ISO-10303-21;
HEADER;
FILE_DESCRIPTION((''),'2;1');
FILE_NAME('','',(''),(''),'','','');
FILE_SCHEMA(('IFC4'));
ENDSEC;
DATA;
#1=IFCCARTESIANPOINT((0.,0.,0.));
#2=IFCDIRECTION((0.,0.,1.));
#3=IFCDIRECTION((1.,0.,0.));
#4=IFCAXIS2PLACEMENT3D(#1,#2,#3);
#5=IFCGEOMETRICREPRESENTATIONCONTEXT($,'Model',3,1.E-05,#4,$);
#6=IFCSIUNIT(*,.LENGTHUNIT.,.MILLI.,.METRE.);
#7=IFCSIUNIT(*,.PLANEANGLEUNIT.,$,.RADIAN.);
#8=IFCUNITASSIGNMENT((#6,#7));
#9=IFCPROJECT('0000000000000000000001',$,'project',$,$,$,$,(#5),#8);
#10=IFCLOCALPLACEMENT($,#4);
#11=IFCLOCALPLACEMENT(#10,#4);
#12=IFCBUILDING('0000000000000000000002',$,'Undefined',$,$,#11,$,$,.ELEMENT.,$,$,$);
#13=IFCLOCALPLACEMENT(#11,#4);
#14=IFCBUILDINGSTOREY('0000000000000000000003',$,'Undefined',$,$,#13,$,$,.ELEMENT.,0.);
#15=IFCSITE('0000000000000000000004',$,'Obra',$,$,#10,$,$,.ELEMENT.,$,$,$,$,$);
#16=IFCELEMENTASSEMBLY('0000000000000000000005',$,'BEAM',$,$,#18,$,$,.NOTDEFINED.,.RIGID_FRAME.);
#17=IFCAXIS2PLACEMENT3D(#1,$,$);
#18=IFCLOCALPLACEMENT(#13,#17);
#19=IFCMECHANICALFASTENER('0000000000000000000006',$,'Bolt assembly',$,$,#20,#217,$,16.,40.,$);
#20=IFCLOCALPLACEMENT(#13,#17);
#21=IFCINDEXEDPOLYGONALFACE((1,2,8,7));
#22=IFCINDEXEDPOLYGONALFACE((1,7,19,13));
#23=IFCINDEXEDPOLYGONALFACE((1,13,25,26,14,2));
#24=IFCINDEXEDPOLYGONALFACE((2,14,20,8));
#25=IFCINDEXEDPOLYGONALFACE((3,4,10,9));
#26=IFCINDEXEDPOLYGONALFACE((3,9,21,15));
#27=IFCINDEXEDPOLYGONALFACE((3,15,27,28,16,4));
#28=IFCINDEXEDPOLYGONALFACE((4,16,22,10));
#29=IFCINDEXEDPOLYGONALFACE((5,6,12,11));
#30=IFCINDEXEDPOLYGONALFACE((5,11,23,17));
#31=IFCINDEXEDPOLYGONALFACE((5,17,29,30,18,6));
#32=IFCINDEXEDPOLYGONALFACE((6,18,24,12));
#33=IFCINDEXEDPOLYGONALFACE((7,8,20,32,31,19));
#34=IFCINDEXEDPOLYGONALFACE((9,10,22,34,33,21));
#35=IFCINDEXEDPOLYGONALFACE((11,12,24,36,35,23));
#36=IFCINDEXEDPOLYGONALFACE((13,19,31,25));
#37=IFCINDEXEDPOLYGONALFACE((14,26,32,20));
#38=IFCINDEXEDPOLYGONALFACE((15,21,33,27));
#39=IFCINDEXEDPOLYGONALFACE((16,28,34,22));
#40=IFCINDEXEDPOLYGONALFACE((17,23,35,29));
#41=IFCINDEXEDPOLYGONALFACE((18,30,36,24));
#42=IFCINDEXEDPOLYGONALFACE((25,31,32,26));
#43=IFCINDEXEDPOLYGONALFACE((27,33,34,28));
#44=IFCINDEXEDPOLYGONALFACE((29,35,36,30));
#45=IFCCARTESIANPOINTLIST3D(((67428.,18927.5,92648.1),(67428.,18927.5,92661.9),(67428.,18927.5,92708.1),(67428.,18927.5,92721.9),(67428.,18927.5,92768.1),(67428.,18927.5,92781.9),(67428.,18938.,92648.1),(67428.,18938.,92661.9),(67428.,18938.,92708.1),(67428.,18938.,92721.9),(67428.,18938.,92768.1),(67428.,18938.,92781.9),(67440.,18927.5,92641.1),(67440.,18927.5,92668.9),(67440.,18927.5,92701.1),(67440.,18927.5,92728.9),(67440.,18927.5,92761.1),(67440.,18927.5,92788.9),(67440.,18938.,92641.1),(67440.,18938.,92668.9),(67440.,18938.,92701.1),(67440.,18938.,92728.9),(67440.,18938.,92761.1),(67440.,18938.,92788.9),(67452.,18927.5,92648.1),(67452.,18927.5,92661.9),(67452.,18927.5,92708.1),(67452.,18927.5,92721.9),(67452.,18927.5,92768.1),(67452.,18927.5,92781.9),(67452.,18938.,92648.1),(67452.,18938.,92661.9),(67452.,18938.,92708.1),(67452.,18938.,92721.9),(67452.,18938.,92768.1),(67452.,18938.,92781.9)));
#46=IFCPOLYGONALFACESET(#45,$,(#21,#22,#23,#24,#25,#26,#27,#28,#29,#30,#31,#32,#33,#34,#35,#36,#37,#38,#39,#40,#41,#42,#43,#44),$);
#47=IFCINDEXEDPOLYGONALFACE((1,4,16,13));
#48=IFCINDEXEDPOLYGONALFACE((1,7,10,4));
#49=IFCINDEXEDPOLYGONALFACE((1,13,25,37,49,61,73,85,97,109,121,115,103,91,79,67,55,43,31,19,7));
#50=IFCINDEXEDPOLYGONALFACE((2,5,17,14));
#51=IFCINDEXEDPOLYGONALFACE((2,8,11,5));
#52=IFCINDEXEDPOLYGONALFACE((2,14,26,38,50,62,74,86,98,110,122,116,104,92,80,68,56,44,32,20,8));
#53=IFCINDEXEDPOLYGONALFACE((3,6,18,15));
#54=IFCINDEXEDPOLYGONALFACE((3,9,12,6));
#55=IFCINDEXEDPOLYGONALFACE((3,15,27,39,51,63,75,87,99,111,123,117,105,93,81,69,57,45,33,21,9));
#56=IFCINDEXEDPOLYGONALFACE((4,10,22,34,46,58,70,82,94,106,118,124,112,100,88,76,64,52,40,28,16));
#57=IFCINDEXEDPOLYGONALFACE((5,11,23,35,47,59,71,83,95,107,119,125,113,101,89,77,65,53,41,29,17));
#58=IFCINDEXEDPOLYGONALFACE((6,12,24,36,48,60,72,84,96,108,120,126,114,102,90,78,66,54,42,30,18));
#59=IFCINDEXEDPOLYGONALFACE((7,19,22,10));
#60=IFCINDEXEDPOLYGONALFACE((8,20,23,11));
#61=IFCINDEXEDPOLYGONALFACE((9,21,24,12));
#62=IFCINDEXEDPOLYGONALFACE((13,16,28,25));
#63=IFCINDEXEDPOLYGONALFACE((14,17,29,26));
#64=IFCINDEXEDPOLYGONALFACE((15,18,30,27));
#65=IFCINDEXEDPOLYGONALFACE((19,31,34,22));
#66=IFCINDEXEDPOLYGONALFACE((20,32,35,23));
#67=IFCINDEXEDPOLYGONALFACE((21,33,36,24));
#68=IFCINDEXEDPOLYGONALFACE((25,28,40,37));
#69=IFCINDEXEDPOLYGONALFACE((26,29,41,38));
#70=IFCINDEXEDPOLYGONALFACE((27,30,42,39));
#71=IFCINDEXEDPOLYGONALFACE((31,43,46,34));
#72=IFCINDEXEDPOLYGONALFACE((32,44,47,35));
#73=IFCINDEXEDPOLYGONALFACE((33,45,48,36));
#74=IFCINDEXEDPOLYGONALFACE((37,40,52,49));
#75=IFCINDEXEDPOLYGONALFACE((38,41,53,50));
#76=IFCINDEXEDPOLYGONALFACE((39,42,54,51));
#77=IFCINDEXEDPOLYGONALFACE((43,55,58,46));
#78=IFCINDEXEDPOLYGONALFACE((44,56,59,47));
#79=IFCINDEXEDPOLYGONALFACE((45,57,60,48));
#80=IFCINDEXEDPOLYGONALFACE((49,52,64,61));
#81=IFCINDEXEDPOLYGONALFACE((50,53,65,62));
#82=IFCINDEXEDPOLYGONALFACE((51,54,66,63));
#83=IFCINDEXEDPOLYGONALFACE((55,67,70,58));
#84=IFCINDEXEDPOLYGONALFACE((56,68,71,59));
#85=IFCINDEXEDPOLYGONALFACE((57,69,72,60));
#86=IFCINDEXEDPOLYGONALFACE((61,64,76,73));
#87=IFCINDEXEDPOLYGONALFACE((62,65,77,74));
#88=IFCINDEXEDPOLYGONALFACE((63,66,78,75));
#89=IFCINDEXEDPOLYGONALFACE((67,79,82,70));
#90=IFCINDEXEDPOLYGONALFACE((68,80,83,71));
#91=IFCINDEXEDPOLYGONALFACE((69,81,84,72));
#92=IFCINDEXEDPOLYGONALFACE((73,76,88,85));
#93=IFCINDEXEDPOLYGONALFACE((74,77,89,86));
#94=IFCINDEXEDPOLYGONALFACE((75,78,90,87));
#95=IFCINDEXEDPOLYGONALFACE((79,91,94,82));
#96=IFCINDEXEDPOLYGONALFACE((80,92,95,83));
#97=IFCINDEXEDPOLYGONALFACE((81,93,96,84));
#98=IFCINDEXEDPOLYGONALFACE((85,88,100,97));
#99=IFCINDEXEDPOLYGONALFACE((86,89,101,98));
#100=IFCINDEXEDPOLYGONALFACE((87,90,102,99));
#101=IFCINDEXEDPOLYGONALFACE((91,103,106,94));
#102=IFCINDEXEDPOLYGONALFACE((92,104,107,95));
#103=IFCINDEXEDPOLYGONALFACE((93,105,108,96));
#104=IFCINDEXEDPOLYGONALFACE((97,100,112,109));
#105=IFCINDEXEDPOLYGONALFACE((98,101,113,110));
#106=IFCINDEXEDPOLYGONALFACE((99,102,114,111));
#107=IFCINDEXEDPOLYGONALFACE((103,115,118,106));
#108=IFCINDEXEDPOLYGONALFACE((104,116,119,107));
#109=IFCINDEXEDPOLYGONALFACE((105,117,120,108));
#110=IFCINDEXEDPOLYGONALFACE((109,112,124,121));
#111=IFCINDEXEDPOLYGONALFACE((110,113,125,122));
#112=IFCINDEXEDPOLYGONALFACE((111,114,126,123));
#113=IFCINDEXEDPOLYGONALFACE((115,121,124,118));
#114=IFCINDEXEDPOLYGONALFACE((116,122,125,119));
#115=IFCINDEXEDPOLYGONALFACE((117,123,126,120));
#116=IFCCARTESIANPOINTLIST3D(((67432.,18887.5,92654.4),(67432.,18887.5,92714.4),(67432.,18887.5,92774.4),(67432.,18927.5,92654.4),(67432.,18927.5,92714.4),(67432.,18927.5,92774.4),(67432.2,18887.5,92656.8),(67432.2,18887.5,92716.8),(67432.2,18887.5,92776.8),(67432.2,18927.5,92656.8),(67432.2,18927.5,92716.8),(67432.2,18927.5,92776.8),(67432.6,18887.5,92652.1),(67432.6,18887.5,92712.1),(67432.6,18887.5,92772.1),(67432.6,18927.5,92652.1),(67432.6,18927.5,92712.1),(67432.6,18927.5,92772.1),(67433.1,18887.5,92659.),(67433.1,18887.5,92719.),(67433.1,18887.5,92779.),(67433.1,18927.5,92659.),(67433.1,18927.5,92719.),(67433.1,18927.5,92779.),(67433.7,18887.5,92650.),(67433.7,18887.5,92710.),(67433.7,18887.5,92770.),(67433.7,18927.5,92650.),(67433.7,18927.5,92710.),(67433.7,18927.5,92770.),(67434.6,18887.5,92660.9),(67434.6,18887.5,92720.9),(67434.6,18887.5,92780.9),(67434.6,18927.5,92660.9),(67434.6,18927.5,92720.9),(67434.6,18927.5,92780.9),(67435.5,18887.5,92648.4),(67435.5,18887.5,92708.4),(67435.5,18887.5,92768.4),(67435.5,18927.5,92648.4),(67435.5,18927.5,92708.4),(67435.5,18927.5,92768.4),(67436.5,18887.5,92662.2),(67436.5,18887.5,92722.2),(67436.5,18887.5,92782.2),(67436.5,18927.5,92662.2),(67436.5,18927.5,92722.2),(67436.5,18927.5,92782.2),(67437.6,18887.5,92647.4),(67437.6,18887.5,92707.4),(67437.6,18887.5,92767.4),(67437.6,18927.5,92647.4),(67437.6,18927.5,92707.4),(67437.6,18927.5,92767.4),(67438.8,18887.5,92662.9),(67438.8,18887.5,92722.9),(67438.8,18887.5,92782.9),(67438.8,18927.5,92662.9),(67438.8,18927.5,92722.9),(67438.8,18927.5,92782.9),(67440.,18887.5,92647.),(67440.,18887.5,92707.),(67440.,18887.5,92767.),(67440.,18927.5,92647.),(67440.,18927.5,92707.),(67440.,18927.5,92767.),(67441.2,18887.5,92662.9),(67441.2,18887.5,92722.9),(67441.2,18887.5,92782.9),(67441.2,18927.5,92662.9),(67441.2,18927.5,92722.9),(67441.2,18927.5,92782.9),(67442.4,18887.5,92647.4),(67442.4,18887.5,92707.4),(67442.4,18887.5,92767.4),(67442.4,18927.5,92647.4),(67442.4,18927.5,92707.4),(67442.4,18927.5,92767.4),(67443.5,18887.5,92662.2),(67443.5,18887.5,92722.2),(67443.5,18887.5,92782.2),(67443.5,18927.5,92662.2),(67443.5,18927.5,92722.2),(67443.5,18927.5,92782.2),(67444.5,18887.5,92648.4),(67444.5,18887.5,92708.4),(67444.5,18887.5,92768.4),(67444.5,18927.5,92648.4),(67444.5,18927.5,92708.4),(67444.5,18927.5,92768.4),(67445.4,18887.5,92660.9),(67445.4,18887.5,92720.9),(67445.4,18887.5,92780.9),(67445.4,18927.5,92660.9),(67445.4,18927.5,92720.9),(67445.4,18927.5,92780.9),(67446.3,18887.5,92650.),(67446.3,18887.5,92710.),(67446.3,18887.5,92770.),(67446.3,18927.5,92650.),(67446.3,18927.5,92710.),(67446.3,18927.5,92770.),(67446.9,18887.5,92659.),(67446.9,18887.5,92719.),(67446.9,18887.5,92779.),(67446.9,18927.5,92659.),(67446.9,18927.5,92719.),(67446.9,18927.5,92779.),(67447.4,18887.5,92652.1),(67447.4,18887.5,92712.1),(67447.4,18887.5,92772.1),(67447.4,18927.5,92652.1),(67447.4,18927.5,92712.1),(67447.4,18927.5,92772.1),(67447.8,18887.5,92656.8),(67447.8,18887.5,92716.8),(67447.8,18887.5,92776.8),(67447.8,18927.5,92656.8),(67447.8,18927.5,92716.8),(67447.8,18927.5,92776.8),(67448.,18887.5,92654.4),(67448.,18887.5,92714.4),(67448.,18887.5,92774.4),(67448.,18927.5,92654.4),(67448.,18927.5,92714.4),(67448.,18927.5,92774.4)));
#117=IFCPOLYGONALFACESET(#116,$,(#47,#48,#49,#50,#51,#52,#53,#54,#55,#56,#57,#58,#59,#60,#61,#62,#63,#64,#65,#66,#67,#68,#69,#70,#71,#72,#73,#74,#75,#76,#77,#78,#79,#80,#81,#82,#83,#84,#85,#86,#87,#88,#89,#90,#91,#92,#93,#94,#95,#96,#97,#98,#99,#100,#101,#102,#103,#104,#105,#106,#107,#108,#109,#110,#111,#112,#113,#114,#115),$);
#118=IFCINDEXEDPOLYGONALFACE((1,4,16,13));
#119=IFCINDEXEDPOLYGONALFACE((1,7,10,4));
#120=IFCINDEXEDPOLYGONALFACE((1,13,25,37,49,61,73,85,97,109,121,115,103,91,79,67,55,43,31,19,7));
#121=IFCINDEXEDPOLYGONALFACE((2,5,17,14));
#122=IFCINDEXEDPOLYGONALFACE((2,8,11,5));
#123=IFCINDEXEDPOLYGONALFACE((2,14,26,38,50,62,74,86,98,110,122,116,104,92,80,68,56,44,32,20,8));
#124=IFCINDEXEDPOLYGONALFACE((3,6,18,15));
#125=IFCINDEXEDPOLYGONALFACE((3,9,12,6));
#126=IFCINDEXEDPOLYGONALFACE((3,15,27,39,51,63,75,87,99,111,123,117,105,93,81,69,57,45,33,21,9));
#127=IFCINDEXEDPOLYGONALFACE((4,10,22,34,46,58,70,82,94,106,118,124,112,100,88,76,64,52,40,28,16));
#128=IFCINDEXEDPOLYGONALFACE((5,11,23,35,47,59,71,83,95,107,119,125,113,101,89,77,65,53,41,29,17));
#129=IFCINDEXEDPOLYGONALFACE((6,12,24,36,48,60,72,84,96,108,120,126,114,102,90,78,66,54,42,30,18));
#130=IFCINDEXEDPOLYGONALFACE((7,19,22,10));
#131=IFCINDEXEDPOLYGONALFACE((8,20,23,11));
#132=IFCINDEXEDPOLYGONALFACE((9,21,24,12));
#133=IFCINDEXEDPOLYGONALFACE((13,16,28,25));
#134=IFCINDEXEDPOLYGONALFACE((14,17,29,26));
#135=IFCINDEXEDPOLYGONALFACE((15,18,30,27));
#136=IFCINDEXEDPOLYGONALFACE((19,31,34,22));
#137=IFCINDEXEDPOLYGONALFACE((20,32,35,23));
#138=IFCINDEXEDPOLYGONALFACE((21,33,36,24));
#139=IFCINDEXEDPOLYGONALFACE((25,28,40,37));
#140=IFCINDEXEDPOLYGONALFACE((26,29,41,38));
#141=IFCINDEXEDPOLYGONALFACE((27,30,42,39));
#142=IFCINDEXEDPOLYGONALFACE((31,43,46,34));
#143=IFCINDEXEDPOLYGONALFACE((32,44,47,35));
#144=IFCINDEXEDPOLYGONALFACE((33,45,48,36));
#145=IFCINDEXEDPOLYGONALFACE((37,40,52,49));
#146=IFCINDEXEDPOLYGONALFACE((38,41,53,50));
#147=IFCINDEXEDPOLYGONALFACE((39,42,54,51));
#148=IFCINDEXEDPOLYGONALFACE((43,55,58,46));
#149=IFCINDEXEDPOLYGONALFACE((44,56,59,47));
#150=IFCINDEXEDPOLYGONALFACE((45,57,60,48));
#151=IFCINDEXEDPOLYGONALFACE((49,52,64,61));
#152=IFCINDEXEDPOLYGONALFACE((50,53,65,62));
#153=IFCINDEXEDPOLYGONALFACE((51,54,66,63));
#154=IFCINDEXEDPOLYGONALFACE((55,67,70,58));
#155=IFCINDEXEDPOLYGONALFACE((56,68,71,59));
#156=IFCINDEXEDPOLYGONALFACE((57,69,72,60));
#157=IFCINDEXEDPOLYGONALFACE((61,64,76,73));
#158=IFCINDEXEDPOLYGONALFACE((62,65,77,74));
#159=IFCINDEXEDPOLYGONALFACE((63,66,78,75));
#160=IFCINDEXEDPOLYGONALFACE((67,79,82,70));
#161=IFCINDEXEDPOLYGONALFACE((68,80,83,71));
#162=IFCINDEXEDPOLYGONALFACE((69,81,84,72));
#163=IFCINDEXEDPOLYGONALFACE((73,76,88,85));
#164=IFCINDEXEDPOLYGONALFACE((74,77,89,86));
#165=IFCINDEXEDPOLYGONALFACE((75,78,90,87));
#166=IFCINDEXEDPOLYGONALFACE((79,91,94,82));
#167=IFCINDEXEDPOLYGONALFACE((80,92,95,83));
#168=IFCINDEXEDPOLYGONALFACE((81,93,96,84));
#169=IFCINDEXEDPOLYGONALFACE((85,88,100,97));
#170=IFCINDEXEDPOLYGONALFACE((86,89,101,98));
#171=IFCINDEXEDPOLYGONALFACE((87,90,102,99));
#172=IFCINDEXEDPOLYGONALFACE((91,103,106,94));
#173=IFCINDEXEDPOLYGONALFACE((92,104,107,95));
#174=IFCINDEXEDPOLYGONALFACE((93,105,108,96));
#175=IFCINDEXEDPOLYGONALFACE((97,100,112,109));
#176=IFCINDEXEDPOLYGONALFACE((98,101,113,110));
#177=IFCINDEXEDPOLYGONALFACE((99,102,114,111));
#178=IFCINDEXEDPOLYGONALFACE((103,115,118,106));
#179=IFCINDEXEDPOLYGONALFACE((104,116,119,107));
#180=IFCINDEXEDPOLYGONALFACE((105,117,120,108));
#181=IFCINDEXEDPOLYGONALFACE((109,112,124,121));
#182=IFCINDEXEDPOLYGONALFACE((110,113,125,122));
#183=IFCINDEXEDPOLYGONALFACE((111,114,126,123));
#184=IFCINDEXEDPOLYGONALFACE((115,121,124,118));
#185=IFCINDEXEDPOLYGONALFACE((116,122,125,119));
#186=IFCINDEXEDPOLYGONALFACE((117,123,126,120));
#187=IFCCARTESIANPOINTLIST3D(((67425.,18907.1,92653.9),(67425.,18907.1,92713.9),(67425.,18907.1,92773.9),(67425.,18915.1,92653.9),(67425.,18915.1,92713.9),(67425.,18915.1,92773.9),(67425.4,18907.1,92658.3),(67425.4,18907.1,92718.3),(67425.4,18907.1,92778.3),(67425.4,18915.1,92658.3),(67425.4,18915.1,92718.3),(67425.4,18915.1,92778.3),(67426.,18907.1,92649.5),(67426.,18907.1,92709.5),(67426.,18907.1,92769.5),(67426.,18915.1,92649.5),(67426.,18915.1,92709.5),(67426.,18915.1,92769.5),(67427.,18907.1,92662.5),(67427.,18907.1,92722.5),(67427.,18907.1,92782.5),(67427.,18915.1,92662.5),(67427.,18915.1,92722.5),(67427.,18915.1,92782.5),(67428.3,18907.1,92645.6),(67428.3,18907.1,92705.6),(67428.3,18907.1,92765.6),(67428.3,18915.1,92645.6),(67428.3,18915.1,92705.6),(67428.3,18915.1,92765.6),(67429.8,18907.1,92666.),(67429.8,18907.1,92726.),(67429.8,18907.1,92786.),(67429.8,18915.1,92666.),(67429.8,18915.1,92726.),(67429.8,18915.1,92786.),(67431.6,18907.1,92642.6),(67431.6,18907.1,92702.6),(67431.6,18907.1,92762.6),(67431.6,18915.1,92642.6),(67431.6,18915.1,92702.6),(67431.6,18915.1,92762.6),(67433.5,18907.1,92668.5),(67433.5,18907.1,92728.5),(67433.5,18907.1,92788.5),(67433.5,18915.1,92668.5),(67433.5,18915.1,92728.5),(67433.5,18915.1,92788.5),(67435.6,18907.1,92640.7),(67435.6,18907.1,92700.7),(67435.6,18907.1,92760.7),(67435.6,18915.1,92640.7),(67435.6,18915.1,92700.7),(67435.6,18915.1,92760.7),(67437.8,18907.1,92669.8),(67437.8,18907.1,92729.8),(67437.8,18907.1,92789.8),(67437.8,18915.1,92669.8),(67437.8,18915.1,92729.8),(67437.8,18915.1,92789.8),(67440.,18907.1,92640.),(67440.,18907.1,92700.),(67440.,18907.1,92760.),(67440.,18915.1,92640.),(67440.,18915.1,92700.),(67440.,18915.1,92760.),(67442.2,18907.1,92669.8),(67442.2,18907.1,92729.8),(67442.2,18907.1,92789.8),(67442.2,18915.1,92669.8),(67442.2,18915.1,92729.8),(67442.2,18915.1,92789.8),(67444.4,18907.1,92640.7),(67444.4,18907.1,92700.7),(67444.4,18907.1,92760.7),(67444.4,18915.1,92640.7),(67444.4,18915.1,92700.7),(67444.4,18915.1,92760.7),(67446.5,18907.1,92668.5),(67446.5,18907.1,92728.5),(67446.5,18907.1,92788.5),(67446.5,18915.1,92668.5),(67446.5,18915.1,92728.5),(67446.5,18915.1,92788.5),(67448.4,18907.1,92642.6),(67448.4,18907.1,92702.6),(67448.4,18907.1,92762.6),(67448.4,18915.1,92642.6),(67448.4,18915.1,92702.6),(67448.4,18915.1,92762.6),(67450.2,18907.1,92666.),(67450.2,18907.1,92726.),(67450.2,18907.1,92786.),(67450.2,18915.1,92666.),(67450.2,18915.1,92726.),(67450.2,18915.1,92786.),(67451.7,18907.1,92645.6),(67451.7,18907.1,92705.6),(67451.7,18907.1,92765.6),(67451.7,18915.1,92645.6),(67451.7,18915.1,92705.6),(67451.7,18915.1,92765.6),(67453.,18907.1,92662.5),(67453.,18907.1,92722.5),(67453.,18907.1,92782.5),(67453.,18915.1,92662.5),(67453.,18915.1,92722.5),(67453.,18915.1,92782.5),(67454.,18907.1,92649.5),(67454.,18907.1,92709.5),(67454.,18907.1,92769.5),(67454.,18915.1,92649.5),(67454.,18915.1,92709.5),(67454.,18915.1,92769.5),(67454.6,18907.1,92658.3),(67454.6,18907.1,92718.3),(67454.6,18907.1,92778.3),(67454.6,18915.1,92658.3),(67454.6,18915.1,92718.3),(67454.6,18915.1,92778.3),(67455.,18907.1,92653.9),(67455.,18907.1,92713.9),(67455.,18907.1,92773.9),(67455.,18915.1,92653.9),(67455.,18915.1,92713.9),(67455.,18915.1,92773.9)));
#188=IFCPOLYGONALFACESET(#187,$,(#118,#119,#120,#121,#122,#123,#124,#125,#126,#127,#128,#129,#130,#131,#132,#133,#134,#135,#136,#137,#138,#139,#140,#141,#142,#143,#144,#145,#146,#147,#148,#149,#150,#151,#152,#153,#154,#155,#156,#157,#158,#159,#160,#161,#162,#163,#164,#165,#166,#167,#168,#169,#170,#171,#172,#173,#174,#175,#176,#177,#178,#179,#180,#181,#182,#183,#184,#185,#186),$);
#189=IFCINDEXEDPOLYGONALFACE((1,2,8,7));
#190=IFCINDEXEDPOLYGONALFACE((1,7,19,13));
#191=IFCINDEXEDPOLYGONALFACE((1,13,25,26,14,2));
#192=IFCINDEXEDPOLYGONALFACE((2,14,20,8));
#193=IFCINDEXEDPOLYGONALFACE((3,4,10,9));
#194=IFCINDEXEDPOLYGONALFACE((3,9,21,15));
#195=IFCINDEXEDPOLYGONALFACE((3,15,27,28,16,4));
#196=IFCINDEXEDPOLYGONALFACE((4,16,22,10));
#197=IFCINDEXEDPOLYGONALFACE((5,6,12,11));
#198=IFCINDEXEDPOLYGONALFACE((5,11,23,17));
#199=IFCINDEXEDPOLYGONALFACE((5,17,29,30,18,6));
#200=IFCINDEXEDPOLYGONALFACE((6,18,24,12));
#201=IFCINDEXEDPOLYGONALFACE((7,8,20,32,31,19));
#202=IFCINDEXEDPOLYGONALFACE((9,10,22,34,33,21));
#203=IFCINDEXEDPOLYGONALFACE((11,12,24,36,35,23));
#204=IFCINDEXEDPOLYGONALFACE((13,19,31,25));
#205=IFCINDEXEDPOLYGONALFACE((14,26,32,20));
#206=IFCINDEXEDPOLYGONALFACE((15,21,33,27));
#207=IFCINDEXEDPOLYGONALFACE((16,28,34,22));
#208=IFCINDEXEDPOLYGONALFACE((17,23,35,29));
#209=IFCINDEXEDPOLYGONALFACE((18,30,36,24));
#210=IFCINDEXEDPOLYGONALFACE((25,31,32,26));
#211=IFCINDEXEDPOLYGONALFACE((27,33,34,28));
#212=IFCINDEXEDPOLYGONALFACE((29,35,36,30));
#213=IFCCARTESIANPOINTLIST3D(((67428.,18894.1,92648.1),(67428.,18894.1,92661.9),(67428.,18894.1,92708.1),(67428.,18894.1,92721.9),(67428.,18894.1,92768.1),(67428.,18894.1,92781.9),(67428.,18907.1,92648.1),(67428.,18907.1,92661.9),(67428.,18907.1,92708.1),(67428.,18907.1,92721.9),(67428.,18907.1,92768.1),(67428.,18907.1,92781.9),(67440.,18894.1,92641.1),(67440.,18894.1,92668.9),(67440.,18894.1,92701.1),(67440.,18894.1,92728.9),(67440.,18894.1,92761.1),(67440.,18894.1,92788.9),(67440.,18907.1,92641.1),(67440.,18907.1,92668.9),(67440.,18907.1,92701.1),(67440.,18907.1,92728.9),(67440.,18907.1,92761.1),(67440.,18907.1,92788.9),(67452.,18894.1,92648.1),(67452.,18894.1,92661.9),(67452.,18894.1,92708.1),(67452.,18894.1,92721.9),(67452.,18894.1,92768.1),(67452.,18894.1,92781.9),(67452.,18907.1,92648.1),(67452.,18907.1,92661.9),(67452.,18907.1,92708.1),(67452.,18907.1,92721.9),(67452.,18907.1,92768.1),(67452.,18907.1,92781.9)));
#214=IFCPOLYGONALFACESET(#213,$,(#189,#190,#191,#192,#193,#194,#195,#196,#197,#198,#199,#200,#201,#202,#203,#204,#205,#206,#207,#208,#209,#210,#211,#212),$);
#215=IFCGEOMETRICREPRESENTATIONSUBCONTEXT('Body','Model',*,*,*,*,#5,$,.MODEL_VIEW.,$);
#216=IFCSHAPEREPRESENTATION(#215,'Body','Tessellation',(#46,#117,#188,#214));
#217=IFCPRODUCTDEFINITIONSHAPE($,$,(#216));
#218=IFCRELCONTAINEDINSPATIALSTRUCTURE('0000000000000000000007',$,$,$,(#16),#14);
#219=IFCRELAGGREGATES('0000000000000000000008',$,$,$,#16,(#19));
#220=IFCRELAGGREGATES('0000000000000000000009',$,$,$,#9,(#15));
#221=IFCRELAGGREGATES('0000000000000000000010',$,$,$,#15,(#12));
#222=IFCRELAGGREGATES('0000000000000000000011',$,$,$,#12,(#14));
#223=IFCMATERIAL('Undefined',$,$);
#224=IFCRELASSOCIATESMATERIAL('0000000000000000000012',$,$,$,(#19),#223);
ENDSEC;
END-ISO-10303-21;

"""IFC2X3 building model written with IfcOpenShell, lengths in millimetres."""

from ifc_helpers import new_model, si_unit, frame, origin_with_axes, origin_2d_with_axis, place, context, subcontext, project, spatial, polyline, circle, outline, extrude, source, transform, mapped, material, element, aggregate, save


model = new_model("IFC2X3")

# Units and contexts
model_context = context("Model", 3, precision=1e-05, world=origin_with_axes())
body_context = subcontext(model_context, "Body", "Model", "MODEL_VIEW")
ifc_project = project(units=[si_unit("LENGTHUNIT", "METRE", prefix="MILLI"), si_unit("PLANEANGLEUNIT", "RADIAN")], contexts=[model_context])

# Site, building, storey
site_placement = place(None, origin_with_axes())
site = spatial("IfcSite", under=ifc_project, at=site_placement, Name="Obra", CompositionType="ELEMENT")
building_placement = place(site_placement, origin_with_axes())
building = spatial("IfcBuilding", under=site, at=building_placement, Name="Undefined", CompositionType="ELEMENT")
storey_placement = place(building_placement, origin_with_axes())
storey = spatial("IfcBuildingStorey", under=building, at=storey_placement, Name="Undefined", CompositionType="ELEMENT", Elevation=0.0)

# Shared definitions
ifc_material_1 = material(Name="Undefined")

# Element assembly, mechanical fastener
assembly_1_placement = place(storey_placement, origin_with_axes())
assembly_1 = element("IfcElementAssembly", 1, at=assembly_1_placement, inside=storey, Name="BEAM", AssemblyPlace="NOTDEFINED", PredefinedType="RIGID_FRAME")
shared_shape_1 = source(origin_with_axes(), body_context, "Body", "SweptSolid", [
    extrude(outline(polyline([(13.9, 0.0), (6.9, 12.0), (-6.9, 12.0), (-13.9, 0.0), (-6.9, -12.0), (6.9, -12.0), (13.9, 0.0)])), frame((0.0, -19.7, 0.0), z_axis=(0.0, 1.0, 0.0), x_axis=(1.0, 0.0, 0.0)), (0.0, 0.0, 1.0), 10.6),
    extrude(circle(Radius=8.0, at=origin_2d_with_axis()), frame((0.0, -9.1, 0.0), z_axis=(0.0, 1.0, 0.0), x_axis=(1.0, 0.0, 0.0)), (0.0, 0.0, 1.0), 40.0),
    extrude(circle(Radius=15.0, at=origin_2d_with_axis()), frame((0.0, 3.3, 0.0), z_axis=(0.0, 1.0, 0.0), x_axis=(1.0, 0.0, 0.0)), (0.0, 0.0, 1.0), 8.0),
    extrude(outline(polyline([(13.9, 0.0), (6.9, 12.0), (-6.9, 12.0), (-13.9, 0.0), (-6.9, -12.0), (6.9, -12.0), (13.9, 0.0)])), frame((0.0, 11.3, 0.0), z_axis=(0.0, 1.0, 0.0), x_axis=(1.0, 0.0, 0.0)), (0.0, 0.0, 1.0), 13.0),
])
mechanical_fastener_1_placement = place(assembly_1_placement, frame((67490.0, 18918.4, 92835.0), z_axis=(-1.0, 0.0, 0.0), x_axis=(0.0, 0.0, -1.0)))
mechanical_fastener_1 = element("IfcMechanicalFastener", 2, at=mechanical_fastener_1_placement, material=ifc_material_1, Name="Bolt assembly", NominalDiameter=16.0, NominalLength=40.0, context=body_context, shape_type="MappedRepresentation", body=[
    mapped(shared_shape_1, transform((60.0, 0.0, 50.0))),
    mapped(shared_shape_1, transform((120.0, 0.0, 50.0))),
    mapped(shared_shape_1, transform((180.0, 0.0, 50.0))),
])
aggregate(assembly_1, [mechanical_fastener_1])

save(model, "model.ifc")
